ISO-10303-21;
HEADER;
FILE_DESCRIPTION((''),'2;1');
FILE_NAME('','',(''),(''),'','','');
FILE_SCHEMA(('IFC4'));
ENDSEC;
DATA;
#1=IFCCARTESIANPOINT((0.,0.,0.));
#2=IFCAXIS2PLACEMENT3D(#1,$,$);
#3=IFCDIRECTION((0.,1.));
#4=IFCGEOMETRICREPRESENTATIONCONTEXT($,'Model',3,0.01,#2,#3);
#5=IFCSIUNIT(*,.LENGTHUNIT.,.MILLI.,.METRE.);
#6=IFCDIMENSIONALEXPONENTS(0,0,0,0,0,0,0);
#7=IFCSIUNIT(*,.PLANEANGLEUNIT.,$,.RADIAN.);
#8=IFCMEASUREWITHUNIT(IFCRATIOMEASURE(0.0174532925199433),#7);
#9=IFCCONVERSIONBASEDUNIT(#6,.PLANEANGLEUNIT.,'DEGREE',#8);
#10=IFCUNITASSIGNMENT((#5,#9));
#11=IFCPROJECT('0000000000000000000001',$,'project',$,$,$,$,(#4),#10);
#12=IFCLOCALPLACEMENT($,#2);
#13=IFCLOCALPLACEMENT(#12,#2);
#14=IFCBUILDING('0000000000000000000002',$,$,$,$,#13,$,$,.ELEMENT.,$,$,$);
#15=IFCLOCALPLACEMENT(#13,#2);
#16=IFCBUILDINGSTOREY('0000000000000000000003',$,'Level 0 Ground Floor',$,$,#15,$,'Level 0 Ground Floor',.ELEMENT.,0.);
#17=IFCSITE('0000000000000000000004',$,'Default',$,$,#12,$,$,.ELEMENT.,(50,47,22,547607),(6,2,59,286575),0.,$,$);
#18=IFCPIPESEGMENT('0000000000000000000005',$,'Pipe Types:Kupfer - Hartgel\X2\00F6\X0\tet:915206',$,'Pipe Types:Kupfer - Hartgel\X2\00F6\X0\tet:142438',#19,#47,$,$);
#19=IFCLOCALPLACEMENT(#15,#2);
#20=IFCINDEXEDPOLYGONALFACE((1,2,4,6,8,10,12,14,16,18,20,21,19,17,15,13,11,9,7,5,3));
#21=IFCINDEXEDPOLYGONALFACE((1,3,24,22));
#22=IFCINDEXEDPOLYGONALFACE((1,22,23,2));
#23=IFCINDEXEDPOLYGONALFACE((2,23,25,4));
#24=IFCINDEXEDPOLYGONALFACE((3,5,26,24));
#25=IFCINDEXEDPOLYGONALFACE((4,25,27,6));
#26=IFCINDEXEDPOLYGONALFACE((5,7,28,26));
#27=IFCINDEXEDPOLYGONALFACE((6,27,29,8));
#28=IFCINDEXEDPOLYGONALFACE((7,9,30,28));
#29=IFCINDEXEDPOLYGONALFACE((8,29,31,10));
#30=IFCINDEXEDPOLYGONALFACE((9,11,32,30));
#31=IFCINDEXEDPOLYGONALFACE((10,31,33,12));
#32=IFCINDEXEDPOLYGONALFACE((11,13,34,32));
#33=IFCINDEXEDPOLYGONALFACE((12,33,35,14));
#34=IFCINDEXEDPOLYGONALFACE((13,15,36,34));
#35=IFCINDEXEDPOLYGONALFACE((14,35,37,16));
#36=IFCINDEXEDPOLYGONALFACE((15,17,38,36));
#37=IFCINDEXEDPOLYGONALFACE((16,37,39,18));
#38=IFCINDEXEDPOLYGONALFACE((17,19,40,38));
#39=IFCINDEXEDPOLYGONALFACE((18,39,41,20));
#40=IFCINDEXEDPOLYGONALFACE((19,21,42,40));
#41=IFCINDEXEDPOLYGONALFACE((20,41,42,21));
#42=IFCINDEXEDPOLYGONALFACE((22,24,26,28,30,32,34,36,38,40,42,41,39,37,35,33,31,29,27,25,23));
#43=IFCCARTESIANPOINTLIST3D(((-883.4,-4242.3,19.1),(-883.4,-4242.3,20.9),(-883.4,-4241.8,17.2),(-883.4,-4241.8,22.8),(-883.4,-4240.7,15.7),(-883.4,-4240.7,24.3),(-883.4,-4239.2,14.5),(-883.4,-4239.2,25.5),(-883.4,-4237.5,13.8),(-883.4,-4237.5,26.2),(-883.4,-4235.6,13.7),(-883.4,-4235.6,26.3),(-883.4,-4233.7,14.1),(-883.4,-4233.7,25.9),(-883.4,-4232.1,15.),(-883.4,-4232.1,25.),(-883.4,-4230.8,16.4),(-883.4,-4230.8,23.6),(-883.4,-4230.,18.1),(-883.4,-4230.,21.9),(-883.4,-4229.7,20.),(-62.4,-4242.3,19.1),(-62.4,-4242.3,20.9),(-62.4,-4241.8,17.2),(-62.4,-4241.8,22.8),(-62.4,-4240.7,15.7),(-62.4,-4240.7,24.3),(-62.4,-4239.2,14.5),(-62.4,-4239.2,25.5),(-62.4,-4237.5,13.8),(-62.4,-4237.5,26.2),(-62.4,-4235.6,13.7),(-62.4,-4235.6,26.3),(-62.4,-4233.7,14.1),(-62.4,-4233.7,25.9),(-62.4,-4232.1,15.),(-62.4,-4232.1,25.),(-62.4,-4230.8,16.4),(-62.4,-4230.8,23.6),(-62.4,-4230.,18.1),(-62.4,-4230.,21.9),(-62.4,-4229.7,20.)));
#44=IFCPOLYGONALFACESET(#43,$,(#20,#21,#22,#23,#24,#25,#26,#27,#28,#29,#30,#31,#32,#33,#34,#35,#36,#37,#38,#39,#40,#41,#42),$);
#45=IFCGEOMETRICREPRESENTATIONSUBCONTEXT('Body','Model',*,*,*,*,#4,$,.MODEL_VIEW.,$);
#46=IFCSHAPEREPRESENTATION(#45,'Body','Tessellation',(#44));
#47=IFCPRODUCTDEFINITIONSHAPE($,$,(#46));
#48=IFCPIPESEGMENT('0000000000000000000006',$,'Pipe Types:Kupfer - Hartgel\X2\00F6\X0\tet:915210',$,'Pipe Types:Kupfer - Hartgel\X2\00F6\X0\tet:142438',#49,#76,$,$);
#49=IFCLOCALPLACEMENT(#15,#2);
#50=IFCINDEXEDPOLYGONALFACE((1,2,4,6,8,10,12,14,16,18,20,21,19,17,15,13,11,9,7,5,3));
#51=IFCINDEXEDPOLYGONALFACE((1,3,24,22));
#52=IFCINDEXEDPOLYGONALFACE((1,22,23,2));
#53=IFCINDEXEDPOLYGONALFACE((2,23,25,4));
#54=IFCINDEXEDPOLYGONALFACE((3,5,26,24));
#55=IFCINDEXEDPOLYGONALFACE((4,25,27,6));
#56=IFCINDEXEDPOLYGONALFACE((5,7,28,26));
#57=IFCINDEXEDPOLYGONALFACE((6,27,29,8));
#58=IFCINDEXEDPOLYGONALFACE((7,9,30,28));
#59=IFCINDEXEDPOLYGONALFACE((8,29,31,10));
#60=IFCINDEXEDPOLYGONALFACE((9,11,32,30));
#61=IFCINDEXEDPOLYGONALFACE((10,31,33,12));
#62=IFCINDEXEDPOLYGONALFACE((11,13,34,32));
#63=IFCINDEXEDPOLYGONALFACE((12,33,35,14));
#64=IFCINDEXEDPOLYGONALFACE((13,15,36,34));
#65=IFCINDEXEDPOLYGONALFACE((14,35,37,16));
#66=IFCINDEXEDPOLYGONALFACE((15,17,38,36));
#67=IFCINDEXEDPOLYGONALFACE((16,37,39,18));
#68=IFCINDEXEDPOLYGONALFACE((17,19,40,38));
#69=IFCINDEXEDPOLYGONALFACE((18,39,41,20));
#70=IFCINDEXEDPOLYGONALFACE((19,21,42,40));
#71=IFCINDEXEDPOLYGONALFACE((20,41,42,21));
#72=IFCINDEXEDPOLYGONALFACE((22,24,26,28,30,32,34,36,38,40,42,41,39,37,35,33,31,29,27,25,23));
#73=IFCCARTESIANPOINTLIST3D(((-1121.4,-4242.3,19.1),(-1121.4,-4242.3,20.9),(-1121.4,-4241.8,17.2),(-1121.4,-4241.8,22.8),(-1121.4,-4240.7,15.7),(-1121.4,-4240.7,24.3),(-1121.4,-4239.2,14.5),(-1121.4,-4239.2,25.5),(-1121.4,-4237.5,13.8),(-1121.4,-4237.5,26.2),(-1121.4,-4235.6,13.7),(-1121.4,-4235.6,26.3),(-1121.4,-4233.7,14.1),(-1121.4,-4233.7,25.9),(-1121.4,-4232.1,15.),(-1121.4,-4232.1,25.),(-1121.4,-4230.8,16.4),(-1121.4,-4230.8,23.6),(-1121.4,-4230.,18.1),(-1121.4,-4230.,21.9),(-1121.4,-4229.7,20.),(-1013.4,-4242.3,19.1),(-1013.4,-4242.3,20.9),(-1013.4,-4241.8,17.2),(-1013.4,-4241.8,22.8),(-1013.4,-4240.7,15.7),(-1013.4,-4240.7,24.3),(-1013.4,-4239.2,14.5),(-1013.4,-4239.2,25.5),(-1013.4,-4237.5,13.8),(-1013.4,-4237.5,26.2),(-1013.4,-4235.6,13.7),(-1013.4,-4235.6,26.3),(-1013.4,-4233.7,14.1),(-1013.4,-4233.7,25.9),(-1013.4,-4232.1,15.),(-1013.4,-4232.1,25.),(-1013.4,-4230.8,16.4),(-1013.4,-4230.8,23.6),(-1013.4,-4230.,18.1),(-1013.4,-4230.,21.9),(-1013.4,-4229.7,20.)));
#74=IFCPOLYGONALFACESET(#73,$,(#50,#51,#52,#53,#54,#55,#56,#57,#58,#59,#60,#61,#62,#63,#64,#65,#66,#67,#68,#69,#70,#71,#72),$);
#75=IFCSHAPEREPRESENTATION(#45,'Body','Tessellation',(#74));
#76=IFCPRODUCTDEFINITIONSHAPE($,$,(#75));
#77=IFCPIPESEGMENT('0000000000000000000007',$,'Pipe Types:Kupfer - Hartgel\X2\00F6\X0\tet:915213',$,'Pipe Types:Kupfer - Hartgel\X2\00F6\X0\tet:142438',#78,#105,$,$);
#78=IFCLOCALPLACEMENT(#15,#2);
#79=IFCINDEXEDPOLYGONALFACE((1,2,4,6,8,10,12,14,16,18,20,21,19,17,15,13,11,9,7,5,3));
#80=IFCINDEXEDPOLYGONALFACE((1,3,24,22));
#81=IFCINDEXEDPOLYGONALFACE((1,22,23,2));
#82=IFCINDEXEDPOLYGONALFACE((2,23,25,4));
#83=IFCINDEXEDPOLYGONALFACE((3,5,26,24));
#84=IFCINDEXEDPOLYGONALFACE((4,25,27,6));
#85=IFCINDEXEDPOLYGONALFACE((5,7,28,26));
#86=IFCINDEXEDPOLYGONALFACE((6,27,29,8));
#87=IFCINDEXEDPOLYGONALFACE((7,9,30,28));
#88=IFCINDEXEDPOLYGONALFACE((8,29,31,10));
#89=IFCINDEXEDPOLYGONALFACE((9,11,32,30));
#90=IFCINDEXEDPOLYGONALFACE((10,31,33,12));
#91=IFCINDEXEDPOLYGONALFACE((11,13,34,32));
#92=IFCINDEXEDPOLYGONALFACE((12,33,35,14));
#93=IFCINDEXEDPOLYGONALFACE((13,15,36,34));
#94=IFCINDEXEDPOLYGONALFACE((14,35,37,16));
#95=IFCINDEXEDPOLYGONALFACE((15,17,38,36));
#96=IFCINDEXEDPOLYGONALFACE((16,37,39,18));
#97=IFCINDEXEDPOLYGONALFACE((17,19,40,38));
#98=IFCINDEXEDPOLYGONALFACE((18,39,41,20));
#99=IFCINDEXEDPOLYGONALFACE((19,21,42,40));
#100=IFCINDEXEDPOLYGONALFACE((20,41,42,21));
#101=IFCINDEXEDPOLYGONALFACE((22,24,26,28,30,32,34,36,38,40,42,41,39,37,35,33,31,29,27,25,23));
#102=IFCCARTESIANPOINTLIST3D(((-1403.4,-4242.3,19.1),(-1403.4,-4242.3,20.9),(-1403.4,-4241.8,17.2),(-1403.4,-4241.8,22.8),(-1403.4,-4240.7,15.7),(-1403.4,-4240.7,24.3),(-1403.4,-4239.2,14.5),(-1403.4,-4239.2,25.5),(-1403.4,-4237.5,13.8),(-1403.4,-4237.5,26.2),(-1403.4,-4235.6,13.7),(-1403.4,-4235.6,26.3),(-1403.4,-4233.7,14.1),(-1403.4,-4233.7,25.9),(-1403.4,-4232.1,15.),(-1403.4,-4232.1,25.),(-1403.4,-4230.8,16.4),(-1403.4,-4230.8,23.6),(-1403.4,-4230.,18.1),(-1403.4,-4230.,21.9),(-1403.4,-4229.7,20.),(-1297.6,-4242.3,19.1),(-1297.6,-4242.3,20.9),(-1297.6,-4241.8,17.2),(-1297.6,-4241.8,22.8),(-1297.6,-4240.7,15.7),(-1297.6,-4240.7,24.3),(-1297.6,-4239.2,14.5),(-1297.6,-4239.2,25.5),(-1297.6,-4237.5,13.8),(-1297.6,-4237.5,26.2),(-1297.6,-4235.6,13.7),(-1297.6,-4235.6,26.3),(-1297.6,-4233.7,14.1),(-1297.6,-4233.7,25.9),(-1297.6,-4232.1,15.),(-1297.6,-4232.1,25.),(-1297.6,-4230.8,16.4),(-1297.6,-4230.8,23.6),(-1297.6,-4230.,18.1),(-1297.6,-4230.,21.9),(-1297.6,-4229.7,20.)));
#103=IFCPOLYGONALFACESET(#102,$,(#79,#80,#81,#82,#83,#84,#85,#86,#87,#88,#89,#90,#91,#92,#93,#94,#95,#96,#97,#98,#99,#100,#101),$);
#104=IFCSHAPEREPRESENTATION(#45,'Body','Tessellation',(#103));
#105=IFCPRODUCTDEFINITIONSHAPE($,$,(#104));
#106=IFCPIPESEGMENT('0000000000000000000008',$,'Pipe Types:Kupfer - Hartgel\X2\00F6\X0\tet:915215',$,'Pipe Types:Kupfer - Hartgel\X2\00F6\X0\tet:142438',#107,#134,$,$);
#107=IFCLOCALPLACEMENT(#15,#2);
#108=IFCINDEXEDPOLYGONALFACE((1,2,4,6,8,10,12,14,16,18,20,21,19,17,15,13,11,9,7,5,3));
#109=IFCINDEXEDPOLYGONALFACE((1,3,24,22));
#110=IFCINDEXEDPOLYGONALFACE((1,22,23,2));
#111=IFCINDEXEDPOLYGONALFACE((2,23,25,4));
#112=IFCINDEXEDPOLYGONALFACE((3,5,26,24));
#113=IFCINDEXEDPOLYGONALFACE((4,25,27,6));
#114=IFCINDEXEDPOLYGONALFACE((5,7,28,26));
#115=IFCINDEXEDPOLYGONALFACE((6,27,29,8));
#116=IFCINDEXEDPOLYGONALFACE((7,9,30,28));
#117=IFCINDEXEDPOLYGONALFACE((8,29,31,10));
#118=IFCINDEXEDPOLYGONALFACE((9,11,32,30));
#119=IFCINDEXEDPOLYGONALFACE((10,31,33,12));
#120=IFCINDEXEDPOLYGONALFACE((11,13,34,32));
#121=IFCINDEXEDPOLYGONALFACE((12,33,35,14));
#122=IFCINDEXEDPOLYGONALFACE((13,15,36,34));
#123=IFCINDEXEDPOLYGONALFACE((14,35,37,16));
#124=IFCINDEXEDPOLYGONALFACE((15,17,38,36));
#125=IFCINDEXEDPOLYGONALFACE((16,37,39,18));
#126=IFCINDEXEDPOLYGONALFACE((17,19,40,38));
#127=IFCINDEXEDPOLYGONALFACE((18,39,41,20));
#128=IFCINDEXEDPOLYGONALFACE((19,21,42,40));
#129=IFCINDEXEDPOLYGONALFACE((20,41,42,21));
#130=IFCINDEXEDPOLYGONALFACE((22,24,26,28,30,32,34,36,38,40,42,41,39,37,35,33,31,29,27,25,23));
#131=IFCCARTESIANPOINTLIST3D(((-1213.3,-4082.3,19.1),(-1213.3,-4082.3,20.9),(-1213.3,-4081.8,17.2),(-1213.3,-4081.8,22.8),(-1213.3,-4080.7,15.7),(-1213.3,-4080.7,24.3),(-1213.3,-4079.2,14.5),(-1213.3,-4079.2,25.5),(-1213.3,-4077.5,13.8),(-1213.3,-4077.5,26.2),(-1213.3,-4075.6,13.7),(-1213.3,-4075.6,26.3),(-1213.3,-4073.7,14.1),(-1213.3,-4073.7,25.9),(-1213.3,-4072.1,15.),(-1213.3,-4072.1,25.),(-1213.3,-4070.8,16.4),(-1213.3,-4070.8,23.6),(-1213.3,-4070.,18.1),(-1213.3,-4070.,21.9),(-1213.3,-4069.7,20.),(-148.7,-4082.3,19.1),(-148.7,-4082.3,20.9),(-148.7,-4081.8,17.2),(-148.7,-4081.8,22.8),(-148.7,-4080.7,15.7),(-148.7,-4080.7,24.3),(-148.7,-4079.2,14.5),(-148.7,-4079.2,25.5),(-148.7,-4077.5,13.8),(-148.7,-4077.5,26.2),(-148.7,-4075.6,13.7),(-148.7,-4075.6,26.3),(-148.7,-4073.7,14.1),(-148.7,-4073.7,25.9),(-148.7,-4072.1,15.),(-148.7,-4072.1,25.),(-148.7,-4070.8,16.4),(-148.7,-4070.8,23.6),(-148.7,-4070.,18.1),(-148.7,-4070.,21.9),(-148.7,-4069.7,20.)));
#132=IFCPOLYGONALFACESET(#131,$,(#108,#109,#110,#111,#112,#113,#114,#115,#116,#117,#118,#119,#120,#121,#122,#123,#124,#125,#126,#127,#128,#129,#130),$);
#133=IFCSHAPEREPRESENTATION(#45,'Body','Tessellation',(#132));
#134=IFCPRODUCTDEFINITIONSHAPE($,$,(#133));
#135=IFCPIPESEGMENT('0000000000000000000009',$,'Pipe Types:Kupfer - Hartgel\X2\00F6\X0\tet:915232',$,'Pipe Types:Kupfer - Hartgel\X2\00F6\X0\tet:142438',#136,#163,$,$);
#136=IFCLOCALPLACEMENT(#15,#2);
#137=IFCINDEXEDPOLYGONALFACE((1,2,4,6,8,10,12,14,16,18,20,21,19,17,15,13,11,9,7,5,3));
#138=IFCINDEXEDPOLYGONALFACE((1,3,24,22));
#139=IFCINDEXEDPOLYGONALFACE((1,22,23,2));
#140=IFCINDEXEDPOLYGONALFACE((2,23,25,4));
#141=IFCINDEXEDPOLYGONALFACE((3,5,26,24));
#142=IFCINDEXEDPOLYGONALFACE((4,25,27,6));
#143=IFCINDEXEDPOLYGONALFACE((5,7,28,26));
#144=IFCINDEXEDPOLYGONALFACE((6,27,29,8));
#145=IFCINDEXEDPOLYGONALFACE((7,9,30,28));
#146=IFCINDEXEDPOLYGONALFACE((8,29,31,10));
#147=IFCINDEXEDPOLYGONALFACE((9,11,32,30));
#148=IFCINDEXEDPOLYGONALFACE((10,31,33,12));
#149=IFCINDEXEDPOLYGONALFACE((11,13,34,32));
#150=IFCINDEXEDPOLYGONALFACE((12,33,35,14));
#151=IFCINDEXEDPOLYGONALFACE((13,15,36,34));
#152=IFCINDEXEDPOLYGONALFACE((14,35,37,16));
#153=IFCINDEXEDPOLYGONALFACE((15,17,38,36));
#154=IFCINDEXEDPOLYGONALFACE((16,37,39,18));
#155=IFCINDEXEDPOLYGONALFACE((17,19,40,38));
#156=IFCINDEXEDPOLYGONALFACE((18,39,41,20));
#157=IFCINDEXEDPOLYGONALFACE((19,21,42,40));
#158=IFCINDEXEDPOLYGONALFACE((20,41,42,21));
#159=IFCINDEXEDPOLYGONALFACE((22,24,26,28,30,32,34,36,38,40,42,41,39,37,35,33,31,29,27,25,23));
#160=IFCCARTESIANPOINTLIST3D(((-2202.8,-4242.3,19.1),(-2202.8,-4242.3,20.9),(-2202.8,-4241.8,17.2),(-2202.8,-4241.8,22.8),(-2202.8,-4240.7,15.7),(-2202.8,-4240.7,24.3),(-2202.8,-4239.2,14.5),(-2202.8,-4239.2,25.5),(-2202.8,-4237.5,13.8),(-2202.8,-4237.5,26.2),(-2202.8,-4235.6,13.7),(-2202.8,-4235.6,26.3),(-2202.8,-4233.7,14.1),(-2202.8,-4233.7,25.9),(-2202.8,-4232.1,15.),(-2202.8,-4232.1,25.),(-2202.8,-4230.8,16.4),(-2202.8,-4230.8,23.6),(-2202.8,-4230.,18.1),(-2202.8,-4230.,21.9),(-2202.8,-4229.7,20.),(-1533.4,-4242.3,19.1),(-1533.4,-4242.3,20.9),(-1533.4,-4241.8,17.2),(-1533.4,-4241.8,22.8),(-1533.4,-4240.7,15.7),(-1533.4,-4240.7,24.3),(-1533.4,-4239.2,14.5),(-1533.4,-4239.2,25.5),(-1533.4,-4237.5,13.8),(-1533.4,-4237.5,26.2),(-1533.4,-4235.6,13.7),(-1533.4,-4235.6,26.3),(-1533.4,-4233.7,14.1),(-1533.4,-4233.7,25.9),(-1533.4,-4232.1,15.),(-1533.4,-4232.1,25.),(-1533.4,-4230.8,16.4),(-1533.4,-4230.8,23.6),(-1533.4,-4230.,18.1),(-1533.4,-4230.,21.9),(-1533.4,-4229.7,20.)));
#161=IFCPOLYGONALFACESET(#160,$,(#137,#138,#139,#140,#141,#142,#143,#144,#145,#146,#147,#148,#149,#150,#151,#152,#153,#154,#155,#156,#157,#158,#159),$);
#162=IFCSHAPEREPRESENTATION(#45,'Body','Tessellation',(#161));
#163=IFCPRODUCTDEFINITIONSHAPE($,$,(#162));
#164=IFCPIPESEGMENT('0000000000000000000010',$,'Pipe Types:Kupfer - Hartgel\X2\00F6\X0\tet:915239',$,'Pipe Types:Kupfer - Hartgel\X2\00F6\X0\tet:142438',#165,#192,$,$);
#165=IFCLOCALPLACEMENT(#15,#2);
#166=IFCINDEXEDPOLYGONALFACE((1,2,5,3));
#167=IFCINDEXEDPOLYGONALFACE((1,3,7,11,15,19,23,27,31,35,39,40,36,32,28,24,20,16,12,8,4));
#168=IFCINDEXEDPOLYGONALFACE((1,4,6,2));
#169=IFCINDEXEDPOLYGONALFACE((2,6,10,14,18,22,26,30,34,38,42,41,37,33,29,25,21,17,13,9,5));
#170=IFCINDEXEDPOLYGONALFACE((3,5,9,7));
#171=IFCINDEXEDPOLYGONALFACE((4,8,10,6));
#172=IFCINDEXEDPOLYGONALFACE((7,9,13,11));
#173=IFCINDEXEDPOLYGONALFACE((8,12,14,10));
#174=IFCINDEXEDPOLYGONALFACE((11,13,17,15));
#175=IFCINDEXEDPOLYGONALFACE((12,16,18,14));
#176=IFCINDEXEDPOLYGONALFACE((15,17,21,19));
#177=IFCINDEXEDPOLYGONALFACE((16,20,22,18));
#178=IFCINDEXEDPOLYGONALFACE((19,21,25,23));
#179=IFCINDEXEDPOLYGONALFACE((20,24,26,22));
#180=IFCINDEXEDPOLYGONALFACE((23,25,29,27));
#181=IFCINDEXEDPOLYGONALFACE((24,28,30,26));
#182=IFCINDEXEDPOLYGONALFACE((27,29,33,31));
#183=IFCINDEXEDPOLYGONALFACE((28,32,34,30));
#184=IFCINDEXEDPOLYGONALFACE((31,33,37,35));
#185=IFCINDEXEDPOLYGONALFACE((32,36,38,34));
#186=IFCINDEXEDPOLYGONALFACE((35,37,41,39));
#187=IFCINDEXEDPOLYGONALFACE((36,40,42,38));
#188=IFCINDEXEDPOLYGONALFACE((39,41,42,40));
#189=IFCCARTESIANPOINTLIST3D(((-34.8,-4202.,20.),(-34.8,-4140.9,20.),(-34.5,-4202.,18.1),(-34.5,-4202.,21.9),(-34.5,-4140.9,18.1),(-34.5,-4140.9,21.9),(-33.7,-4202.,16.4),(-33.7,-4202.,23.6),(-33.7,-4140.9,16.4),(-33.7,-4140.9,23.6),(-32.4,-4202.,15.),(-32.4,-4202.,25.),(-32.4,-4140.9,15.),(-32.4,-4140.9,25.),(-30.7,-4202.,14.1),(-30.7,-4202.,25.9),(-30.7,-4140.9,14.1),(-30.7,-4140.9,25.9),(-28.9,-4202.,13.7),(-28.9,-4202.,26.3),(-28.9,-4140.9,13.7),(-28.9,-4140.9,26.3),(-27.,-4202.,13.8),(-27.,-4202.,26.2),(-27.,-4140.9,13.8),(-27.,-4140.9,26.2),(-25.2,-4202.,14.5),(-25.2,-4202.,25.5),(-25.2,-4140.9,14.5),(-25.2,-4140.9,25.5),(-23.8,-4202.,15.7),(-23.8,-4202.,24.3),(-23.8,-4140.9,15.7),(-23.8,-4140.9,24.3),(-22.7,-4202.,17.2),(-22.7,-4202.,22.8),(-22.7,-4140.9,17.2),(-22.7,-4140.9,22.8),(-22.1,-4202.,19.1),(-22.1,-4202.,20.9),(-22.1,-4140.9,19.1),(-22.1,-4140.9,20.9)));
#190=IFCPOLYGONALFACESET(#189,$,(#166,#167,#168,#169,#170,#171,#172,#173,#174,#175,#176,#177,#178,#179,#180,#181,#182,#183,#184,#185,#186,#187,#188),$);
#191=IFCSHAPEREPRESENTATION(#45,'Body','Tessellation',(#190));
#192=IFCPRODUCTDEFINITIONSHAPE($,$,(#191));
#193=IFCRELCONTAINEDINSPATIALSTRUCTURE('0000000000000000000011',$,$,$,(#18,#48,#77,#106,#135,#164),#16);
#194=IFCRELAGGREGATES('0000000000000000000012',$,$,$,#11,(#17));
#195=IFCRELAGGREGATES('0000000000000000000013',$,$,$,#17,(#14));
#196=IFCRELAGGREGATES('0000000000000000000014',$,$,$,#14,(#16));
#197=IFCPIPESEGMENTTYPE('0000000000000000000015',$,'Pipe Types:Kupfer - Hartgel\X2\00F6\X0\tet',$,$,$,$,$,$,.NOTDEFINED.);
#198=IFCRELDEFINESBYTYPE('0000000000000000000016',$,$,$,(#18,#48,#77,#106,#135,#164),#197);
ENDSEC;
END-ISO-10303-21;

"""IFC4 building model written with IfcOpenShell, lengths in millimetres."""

from ifc_helpers import new_model, entity, si_unit, converted_unit, direction, frame, frame_2d, origin, place, context, subcontext, project, spatial, circle, extrude, type_object, element, save


model = new_model("IFC4")

# Units and contexts
model_context = context("Model", 3, precision=0.01, world=origin(), true_north=direction((0.0, 1.0)))
body_context = subcontext(model_context, "Body", "Model", "MODEL_VIEW")
ifc_project = project(units=[si_unit("LENGTHUNIT", "METRE", prefix="MILLI"), converted_unit("PLANEANGLEUNIT", "DEGREE", entity("IfcRatioMeasure", 0.0174532925199433), si_unit("PLANEANGLEUNIT", "RADIAN"), dimensions=[0, 0, 0, 0, 0, 0, 0])], contexts=[model_context])

# Site, building, storey
site_placement = place(None, origin())
site = spatial("IfcSite", under=ifc_project, at=site_placement, Name="Default", CompositionType="ELEMENT", RefLatitude=(50, 47, 22, 547607), RefLongitude=(6, 2, 59, 286575), RefElevation=0.0)
building_placement = place(site_placement, origin())
building = spatial("IfcBuilding", under=site, at=building_placement, CompositionType="ELEMENT")
storey_placement = place(building_placement, origin())
storey = spatial("IfcBuildingStorey", under=building, at=storey_placement, Name="Level 0 Ground Floor", LongName="Level 0 Ground Floor", CompositionType="ELEMENT", Elevation=0.0)

# Pipe segments
pipe_segment_type = type_object("IfcPipeSegmentType", Name="Pipe Types:Kupfer - Hartgelötet", PredefinedType="NOTDEFINED")
pipe_segment_1_placement = place(storey_placement, frame((-883.4, -4244.0, 12.1)))
element("IfcPipeSegment", 1, at=pipe_segment_1_placement, inside=storey, type_object=pipe_segment_type, Name="Pipe Types:Kupfer - Hartgelötet:915206", ObjectType="Pipe Types:Kupfer - Hartgelötet:142438", context=body_context, shape_type="SweptSolid", body=[
    extrude(circle(Radius=6.3, at=frame_2d((0.0, 0.0), x_axis=(1.0, 0.0))), frame((0.0, 7.9, 7.9), z_axis=(1.0, 0.0, 0.0), x_axis=(0.0, 1.0, 0.0)), (0.0, 0.0, 1.0), 821.0),
])
pipe_segment_2_placement = place(storey_placement, frame((-1121.4, -4244.0, 12.1)))
element("IfcPipeSegment", 2, at=pipe_segment_2_placement, inside=storey, type_object=pipe_segment_type, Name="Pipe Types:Kupfer - Hartgelötet:915210", ObjectType="Pipe Types:Kupfer - Hartgelötet:142438", context=body_context, shape_type="SweptSolid", body=[
    extrude(circle(Radius=6.3, at=frame_2d((0.0, 0.0), x_axis=(1.0, 0.0))), frame((0.0, 7.9, 7.9), z_axis=(1.0, 0.0, 0.0), x_axis=(0.0, 1.0, 0.0)), (0.0, 0.0, 1.0), 108.0),
])
pipe_segment_3_placement = place(storey_placement, frame((-1403.4, -4244.0, 12.1)))
element("IfcPipeSegment", 3, at=pipe_segment_3_placement, inside=storey, type_object=pipe_segment_type, Name="Pipe Types:Kupfer - Hartgelötet:915213", ObjectType="Pipe Types:Kupfer - Hartgelötet:142438", context=body_context, shape_type="SweptSolid", body=[
    extrude(circle(Radius=6.3, at=frame_2d((0.0, 0.0), x_axis=(1.0, 0.0))), frame((0.0, 7.9, 7.9), z_axis=(1.0, 0.0, 0.0), x_axis=(0.0, 1.0, 0.0)), (0.0, 0.0, 1.0), 105.8),
])
pipe_segment_4_placement = place(storey_placement, frame((-1213.3, -4084.0, 12.1)))
element("IfcPipeSegment", 4, at=pipe_segment_4_placement, inside=storey, type_object=pipe_segment_type, Name="Pipe Types:Kupfer - Hartgelötet:915215", ObjectType="Pipe Types:Kupfer - Hartgelötet:142438", context=body_context, shape_type="SweptSolid", body=[
    extrude(circle(Radius=6.3, at=frame_2d((0.0, 0.0), x_axis=(1.0, 0.0))), frame((0.0, 7.9, 7.9), z_axis=(1.0, 0.0, 0.0), x_axis=(0.0, 1.0, 0.0)), (0.0, 0.0, 1.0), 1064.6),
])
pipe_segment_5_placement = place(storey_placement, frame((-2202.8, -4244.0, 12.1)))
element("IfcPipeSegment", 5, at=pipe_segment_5_placement, inside=storey, type_object=pipe_segment_type, Name="Pipe Types:Kupfer - Hartgelötet:915232", ObjectType="Pipe Types:Kupfer - Hartgelötet:142438", context=body_context, shape_type="SweptSolid", body=[
    extrude(circle(Radius=6.3, at=frame_2d((0.0, 0.0), x_axis=(1.0, 0.0))), frame((0.0, 7.9, 7.9), z_axis=(1.0, 0.000044, 0.0), x_axis=(-0.000044, 1.0, 0.0)), (0.0, 0.0, 1.0), 669.4),
])
pipe_segment_6_placement = place(storey_placement, frame((-36.4, -4202.0, 12.1)))
element("IfcPipeSegment", 6, at=pipe_segment_6_placement, inside=storey, type_object=pipe_segment_type, Name="Pipe Types:Kupfer - Hartgelötet:915239", ObjectType="Pipe Types:Kupfer - Hartgelötet:142438", context=body_context, shape_type="SweptSolid", body=[
    extrude(circle(Radius=6.3, at=frame_2d((0.0, 0.0), x_axis=(1.0, 0.0))), frame((7.9, 0.0, 7.9), z_axis=(0.0, 1.0, 0.0), x_axis=(-1.0, 0.0, 0.0)), (0.0, 0.0, 1.0), 61.1),
])

save(model, "model.ifc")
